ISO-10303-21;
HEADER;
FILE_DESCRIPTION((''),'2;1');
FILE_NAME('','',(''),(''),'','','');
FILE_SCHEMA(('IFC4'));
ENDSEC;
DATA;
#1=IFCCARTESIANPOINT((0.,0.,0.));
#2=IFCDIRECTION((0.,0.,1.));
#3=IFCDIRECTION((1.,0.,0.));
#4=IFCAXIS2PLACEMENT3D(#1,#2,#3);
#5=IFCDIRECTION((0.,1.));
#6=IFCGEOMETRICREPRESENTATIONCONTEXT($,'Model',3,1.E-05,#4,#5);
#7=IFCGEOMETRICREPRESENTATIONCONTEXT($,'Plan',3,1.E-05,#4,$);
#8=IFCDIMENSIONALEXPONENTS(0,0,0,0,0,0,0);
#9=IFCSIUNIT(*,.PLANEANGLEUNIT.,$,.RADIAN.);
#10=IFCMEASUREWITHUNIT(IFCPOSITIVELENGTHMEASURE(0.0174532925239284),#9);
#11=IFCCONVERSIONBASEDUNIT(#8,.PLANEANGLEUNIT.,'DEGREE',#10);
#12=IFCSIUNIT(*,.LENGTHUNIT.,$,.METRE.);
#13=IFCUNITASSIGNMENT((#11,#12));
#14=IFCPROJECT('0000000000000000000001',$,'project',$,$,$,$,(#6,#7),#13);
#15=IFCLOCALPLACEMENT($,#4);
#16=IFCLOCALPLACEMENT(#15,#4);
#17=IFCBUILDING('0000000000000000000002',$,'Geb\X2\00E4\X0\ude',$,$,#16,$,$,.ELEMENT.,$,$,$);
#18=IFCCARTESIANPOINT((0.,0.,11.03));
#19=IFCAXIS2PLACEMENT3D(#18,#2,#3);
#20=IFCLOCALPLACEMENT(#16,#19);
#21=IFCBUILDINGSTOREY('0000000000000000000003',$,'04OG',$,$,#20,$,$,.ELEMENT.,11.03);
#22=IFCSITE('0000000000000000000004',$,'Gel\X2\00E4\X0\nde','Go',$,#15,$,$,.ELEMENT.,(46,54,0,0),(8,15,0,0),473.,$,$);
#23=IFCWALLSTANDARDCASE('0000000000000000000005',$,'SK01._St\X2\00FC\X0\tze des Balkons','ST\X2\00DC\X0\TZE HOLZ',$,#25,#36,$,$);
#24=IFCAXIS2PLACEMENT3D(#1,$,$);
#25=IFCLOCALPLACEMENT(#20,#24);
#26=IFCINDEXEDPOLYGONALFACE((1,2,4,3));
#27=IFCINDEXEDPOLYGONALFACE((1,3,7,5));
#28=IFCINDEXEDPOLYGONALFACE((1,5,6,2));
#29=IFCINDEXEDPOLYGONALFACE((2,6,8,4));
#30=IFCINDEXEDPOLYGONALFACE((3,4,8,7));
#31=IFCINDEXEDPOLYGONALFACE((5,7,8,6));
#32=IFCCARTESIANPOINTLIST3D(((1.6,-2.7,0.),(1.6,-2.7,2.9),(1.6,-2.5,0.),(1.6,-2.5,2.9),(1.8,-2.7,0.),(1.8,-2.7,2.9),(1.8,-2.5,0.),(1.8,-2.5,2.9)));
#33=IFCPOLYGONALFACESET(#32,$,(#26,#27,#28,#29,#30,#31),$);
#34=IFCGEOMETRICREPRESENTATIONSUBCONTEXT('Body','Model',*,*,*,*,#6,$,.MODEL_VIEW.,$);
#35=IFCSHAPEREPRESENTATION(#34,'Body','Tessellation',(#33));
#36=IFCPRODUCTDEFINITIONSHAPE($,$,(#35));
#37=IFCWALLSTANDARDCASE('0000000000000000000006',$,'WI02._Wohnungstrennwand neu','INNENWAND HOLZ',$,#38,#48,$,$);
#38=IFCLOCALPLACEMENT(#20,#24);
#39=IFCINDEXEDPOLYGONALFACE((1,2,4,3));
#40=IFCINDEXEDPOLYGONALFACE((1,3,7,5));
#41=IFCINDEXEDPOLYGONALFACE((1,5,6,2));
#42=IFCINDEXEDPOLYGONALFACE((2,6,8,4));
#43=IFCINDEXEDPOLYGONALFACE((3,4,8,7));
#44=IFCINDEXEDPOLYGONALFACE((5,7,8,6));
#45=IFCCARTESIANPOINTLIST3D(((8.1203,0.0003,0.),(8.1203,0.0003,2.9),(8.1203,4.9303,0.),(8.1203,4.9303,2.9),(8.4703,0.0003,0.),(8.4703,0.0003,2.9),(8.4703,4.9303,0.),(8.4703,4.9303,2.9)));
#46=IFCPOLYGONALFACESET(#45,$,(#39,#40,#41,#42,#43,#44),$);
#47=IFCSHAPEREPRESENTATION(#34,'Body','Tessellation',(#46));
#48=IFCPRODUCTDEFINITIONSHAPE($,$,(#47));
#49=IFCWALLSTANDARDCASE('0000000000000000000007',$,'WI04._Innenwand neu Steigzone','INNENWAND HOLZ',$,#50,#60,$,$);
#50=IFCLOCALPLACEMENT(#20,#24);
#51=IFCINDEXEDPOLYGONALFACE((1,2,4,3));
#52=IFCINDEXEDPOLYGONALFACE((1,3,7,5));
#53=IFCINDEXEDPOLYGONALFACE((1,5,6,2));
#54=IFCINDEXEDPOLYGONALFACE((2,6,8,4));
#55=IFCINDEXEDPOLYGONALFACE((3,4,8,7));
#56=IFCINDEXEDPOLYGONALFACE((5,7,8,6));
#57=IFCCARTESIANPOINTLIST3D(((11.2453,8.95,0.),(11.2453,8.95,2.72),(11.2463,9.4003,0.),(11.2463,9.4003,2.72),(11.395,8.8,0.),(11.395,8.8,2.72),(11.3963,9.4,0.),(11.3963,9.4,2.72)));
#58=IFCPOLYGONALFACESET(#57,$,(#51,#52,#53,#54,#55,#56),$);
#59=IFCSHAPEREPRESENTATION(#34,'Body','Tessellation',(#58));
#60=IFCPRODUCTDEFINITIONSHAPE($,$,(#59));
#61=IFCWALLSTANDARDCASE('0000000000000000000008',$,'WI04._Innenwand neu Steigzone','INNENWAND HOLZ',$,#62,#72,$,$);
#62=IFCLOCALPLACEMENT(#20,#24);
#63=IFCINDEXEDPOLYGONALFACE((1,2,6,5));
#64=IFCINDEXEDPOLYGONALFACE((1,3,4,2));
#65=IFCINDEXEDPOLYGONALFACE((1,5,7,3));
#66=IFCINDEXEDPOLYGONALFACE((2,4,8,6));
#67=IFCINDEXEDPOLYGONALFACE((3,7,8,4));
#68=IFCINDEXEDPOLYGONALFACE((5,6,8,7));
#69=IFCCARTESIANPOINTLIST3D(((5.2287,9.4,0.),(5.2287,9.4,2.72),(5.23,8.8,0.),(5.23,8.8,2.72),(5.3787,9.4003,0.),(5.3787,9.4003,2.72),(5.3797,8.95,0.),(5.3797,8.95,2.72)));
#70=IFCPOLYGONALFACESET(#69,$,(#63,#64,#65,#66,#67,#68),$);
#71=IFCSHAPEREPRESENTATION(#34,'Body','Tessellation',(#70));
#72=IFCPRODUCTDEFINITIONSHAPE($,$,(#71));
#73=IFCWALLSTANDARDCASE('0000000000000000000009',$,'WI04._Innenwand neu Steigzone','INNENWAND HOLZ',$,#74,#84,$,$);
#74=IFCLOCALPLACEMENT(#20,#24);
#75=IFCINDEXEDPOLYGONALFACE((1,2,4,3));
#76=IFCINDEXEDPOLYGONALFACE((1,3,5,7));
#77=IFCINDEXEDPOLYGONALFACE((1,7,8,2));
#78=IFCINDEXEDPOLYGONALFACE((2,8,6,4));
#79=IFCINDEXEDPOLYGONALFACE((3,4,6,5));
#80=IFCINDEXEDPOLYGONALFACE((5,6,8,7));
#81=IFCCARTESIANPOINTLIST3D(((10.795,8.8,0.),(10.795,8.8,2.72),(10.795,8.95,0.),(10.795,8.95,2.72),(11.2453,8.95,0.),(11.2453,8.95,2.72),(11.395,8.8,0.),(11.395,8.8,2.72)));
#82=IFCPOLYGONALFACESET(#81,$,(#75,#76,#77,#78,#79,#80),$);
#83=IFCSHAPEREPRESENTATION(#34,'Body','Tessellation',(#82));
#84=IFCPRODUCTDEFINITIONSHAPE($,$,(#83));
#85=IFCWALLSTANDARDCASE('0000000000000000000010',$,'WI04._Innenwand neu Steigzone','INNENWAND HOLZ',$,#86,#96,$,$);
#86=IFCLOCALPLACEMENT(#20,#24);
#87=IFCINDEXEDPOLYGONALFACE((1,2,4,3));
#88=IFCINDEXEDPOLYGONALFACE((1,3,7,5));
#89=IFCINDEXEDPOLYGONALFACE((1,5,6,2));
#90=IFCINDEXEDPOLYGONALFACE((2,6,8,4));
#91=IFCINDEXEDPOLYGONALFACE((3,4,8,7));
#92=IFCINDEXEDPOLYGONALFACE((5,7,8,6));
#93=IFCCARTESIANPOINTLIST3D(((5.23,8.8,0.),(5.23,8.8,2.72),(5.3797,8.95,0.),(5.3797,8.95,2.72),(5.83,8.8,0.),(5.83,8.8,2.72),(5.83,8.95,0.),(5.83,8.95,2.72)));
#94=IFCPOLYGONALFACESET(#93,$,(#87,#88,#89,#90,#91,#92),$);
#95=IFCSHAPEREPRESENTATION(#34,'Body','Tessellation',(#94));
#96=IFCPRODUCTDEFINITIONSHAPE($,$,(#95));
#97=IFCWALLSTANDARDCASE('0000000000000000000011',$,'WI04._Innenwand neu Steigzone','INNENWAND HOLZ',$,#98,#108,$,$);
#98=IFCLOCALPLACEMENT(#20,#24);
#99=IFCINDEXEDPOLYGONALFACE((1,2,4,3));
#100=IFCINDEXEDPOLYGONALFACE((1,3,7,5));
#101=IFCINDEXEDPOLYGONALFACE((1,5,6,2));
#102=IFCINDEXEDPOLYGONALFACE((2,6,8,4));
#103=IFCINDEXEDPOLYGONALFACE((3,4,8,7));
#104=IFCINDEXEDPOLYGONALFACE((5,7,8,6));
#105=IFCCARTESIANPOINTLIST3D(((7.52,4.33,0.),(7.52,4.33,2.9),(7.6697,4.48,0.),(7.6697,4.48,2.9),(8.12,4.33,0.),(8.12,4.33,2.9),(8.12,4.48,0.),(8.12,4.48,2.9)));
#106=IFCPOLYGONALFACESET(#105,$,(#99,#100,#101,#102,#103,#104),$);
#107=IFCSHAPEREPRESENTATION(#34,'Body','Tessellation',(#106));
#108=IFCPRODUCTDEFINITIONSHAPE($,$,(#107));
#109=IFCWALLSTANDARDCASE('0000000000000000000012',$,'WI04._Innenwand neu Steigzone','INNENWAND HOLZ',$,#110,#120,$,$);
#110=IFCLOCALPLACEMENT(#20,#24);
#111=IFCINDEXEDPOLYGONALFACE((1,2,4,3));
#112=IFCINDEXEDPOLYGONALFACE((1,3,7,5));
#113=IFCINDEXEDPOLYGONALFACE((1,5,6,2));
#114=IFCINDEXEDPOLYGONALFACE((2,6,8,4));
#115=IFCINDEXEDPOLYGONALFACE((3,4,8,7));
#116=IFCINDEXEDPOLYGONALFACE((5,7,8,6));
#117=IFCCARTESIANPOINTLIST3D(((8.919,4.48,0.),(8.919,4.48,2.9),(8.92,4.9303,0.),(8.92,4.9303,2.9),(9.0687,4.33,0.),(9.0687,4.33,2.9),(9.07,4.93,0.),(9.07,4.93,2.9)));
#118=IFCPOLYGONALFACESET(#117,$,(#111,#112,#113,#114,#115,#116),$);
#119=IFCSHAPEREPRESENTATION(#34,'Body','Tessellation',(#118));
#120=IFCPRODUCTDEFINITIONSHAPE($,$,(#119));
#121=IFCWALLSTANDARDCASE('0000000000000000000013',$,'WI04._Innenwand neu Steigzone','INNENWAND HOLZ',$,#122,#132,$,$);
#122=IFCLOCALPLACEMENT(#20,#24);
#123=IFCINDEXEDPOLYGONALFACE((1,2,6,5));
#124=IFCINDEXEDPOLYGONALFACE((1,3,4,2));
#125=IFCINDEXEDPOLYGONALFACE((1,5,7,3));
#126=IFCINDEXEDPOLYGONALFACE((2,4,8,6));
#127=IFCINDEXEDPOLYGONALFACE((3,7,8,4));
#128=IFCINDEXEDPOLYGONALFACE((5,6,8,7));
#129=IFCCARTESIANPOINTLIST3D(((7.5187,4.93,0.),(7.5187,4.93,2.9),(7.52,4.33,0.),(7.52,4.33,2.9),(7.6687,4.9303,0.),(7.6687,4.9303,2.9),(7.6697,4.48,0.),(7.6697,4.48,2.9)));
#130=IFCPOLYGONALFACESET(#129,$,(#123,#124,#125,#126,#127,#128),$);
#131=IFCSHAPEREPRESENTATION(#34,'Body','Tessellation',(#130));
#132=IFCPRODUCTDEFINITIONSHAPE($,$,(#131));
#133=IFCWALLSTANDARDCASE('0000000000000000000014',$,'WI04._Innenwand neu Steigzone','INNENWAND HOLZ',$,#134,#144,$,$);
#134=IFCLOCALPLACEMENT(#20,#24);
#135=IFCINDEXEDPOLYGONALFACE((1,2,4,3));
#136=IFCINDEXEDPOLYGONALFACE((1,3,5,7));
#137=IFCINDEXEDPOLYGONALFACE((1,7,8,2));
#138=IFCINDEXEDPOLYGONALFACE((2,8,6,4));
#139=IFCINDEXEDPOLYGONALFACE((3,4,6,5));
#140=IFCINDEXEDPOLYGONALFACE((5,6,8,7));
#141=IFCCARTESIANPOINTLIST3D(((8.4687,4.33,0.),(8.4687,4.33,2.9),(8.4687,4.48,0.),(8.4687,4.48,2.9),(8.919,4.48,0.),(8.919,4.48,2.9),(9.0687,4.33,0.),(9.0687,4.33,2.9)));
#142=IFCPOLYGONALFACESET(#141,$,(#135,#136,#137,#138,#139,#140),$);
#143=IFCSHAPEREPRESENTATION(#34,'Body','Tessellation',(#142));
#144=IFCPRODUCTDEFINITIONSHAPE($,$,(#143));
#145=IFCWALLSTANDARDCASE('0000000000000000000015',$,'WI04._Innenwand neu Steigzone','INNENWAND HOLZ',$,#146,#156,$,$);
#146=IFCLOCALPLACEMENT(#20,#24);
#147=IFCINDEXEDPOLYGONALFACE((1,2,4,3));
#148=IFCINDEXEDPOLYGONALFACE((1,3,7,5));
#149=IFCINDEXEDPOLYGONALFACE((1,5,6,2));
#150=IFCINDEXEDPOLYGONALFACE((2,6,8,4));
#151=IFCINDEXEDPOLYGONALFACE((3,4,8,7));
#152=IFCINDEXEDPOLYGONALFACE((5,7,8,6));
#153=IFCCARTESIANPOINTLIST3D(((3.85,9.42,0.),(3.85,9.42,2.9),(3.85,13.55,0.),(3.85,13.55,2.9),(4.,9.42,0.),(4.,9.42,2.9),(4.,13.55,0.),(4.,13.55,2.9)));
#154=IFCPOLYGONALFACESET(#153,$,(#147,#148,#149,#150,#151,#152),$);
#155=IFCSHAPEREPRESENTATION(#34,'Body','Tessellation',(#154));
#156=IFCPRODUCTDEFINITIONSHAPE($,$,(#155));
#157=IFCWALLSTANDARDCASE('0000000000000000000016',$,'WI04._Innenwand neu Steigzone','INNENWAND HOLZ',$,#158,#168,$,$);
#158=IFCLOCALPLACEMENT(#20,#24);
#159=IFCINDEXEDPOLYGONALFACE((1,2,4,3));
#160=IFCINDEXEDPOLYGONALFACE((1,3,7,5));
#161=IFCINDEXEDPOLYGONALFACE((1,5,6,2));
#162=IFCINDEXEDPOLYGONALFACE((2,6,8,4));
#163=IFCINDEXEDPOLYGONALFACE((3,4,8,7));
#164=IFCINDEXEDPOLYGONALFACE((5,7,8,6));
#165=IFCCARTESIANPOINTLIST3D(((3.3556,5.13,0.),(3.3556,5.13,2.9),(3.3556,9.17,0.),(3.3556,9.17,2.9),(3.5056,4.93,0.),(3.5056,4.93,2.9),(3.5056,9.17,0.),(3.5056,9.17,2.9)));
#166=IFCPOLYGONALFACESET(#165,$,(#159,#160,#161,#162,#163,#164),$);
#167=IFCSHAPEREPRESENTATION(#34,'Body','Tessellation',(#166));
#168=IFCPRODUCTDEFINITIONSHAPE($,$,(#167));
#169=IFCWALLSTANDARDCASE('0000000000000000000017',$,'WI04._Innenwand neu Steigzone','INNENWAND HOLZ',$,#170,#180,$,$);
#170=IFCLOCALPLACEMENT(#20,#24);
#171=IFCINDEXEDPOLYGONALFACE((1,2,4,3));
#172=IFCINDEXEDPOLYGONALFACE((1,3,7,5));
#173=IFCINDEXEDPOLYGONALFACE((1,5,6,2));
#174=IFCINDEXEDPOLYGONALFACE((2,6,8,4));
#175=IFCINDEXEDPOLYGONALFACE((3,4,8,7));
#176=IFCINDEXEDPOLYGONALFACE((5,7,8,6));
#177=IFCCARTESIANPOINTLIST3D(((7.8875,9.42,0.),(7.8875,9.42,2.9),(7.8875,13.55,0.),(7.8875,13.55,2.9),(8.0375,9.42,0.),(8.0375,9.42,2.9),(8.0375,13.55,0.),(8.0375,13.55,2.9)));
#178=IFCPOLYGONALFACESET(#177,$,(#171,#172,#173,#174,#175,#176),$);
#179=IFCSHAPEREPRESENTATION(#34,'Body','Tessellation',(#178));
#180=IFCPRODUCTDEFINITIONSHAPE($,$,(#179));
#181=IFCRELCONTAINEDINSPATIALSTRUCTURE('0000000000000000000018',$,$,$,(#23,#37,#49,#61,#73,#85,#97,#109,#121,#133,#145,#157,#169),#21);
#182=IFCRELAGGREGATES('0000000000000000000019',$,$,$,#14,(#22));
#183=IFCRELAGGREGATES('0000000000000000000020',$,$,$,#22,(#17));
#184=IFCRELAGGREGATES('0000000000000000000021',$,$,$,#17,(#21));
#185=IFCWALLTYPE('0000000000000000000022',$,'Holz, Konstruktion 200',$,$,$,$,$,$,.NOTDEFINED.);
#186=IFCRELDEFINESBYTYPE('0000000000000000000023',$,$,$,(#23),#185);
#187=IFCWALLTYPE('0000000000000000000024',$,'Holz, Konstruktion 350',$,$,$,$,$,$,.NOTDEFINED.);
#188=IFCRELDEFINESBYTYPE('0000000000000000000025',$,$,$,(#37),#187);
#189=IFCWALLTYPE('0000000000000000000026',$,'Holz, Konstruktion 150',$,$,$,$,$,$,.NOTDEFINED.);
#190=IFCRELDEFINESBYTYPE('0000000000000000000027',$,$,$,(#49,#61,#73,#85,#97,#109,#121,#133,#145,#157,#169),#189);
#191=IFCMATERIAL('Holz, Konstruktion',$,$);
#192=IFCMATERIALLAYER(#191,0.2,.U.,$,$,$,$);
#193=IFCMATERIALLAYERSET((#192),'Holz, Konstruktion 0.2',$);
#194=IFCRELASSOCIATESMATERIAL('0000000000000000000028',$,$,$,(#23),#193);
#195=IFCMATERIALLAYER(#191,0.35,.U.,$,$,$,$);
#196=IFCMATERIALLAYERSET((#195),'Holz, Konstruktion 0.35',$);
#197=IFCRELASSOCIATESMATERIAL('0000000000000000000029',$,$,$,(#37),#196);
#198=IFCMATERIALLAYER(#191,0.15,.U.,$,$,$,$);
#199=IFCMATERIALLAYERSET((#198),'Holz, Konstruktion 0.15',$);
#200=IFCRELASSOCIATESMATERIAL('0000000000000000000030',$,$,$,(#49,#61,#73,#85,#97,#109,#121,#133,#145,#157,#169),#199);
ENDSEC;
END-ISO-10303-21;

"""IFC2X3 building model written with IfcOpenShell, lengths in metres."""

from ifc_helpers import new_model, entity, si_unit, converted_unit, direction, frame, origin_with_axes, place, context, subcontext, project, spatial, polyline, outline, extrude, material, layer, layer_set, layer_usage, type_object, element, save


model = new_model("IFC2X3")

# Units and contexts
model_context = context("Model", 3, precision=1e-05, world=origin_with_axes(), true_north=direction((0.0, 1.0)))
plan_context = context("Plan", 3, precision=1e-05, world=origin_with_axes())
body_context = subcontext(model_context, "Body", "Model", "MODEL_VIEW")
ifc_project = project(units=[converted_unit("PLANEANGLEUNIT", "DEGREE", entity("IfcPositiveLengthMeasure", 0.0174532925239284), si_unit("PLANEANGLEUNIT", "RADIAN"), dimensions=[0, 0, 0, 0, 0, 0, 0]), si_unit("LENGTHUNIT", "METRE")], contexts=[model_context, plan_context])

# Site, building, storey
site_placement = place(None, origin_with_axes())
site = spatial("IfcSite", under=ifc_project, at=site_placement, Name="Gelände", Description="Go", CompositionType="ELEMENT", RefLatitude=(46, 54, 0, 0), RefLongitude=(8, 15, 0, 0), RefElevation=473.0)
building_placement = place(site_placement, origin_with_axes())
building = spatial("IfcBuilding", under=site, at=building_placement, Name="Gebäude", CompositionType="ELEMENT")
storey_placement = place(building_placement, frame((0.0, 0.0, 11.03), z_axis=(0.0, 0.0, 1.0), x_axis=(1.0, 0.0, 0.0)))
storey = spatial("IfcBuildingStorey", under=building, at=storey_placement, Name="04OG", CompositionType="ELEMENT", Elevation=11.03)

# Shared definitions
ifc_material_1 = material(Name="Holz, Konstruktion")

# Walls
ifc_layer_1 = layer(ifc_material_1, 0.2, ventilated="UNKNOWN")
ifc_layer_set_1 = layer_set([ifc_layer_1], Name="Holz, Konstruktion 0.2")
wall_type_1 = type_object("IfcWallType", Name="Holz, Konstruktion 200", PredefinedType="NOTDEFINED")
ifc_layer_usage_1 = layer_usage(ifc_layer_set_1, "AXIS2", "NEGATIVE", 0.0)
wall_1_placement = place(storey_placement, frame((1.6, -2.7, 0.0), z_axis=(0.0, 0.0, 1.0), x_axis=(0.0, 1.0, 0.0)))
element("IfcWallStandardCase", 1, at=wall_1_placement, inside=storey, type_object=wall_type_1, material=ifc_layer_usage_1, Name="SK01._Stütze des Balkons", Description="STÜTZE HOLZ", context=body_context, shape_type="SweptSolid", body=[
    extrude(outline(polyline([(0.0, -0.2), (0.2, -0.2), (0.2, 0.0), (0.0, 0.0), (0.0, -0.2)])), origin_with_axes(), (0.0, 0.0, 1.0), 2.9),
])
ifc_layer_2 = layer(ifc_material_1, 0.35, ventilated="UNKNOWN")
ifc_layer_set_2 = layer_set([ifc_layer_2], Name="Holz, Konstruktion 0.35")
ifc_layer_usage_2 = layer_usage(ifc_layer_set_2, "AXIS2", "POSITIVE", 0.0)
wall_type_2 = type_object("IfcWallType", Name="Holz, Konstruktion 350", PredefinedType="NOTDEFINED")
wall_2_placement = place(storey_placement, frame((8.1203, 4.9303, 0.0), z_axis=(0.0, 0.0, 1.0), x_axis=(0.0, -1.0, 0.0)))
element("IfcWallStandardCase", 2, at=wall_2_placement, inside=storey, type_object=wall_type_2, material=ifc_layer_usage_2, Name="WI02._Wohnungstrennwand neu", Description="INNENWAND HOLZ", context=body_context, shape_type="SweptSolid", body=[
    extrude(outline(polyline([(0.0, 0.0), (4.93, 0.0), (4.93, 0.35), (0.0, 0.35), (0.0, 0.0)])), origin_with_axes(), (0.0, 0.0, 1.0), 2.9),
])
ifc_layer_3 = layer(ifc_material_1, 0.15, ventilated="UNKNOWN")
ifc_layer_set_3 = layer_set([ifc_layer_3], Name="Holz, Konstruktion 0.15")
ifc_layer_usage_3 = layer_usage(ifc_layer_set_3, "AXIS2", "NEGATIVE", 0.0)
wall_type_3 = type_object("IfcWallType", Name="Holz, Konstruktion 150", PredefinedType="NOTDEFINED")
wall_3_placement = place(storey_placement, frame((11.3963, 9.4, 0.0), z_axis=(0.0, 0.0, 1.0), x_axis=(-0.002118, -0.999998, 0.0)))
element("IfcWallStandardCase", 3, at=wall_3_placement, inside=storey, type_object=wall_type_3, material=ifc_layer_usage_3, Name="WI04._Innenwand neu Steigzone", Description="INNENWAND HOLZ", context=body_context, shape_type="SweptSolid", body=[
    extrude(outline(polyline([(0.0, -0.15), (0.4503, -0.15), (0.6, 0.0), (0.0, 0.0), (0.0, -0.15)])), origin_with_axes(), (0.0, 0.0, 1.0), 2.72),
])
ifc_layer_usage_4 = layer_usage(ifc_layer_set_3, "AXIS2", "POSITIVE", 0.0)
wall_4_placement = place(storey_placement, frame((5.2287, 9.4, 0.0), z_axis=(0.0, 0.0, 1.0), x_axis=(0.002118, -0.999998, 0.0)))
element("IfcWallStandardCase", 4, at=wall_4_placement, inside=storey, type_object=wall_type_3, material=ifc_layer_usage_4, Name="WI04._Innenwand neu Steigzone", Description="INNENWAND HOLZ", context=body_context, shape_type="SweptSolid", body=[
    extrude(outline(polyline([(0.0, 0.0), (0.6, 0.0), (0.4503, 0.15), (0.0, 0.15), (0.0, 0.0)])), origin_with_axes(), (0.0, 0.0, 1.0), 2.72),
])
ifc_layer_usage_5 = layer_usage(ifc_layer_set_3, "AXIS2", "NEGATIVE", 0.0)
wall_5_placement = place(storey_placement, frame((11.395, 8.8, 0.0), z_axis=(0.0, 0.0, 1.0), x_axis=(-1.0, 0.0, 0.0)))
element("IfcWallStandardCase", 5, at=wall_5_placement, inside=storey, type_object=wall_type_3, material=ifc_layer_usage_5, Name="WI04._Innenwand neu Steigzone", Description="INNENWAND HOLZ", context=body_context, shape_type="SweptSolid", body=[
    extrude(outline(polyline([(0.1497, -0.15), (0.6, -0.15), (0.6, 0.0), (0.0, 0.0), (0.1497, -0.15)])), origin_with_axes(), (0.0, 0.0, 1.0), 2.72),
])
ifc_layer_usage_6 = layer_usage(ifc_layer_set_3, "AXIS2", "POSITIVE", 0.0)
wall_6_placement = place(storey_placement, frame((5.23, 8.8, 0.0), z_axis=(0.0, 0.0, 1.0), x_axis=(1.0, 0.0, 0.0)))
element("IfcWallStandardCase", 6, at=wall_6_placement, inside=storey, type_object=wall_type_3, material=ifc_layer_usage_6, Name="WI04._Innenwand neu Steigzone", Description="INNENWAND HOLZ", context=body_context, shape_type="SweptSolid", body=[
    extrude(outline(polyline([(0.0, 0.0), (0.6, 0.0), (0.6, 0.15), (0.1497, 0.15), (0.0, 0.0)])), origin_with_axes(), (0.0, 0.0, 1.0), 2.72),
])
ifc_layer_usage_7 = layer_usage(ifc_layer_set_3, "AXIS2", "POSITIVE", 0.0)
wall_7_placement = place(storey_placement, frame((7.52, 4.33, 0.0), z_axis=(0.0, 0.0, 1.0), x_axis=(1.0, 0.0, 0.0)))
element("IfcWallStandardCase", 7, at=wall_7_placement, inside=storey, type_object=wall_type_3, material=ifc_layer_usage_7, Name="WI04._Innenwand neu Steigzone", Description="INNENWAND HOLZ", context=body_context, shape_type="SweptSolid", body=[
    extrude(outline(polyline([(0.0, 0.0), (0.6, 0.0), (0.6, 0.15), (0.1497, 0.15), (0.0, 0.0)])), origin_with_axes(), (0.0, 0.0, 1.0), 2.9),
])
ifc_layer_usage_8 = layer_usage(ifc_layer_set_3, "AXIS2", "POSITIVE", 0.0)
wall_8_placement = place(storey_placement, frame((9.0687, 4.33, 0.0), z_axis=(0.0, 0.0, 1.0), x_axis=(0.002118, 0.999998, 0.0)))
element("IfcWallStandardCase", 8, at=wall_8_placement, inside=storey, type_object=wall_type_3, material=ifc_layer_usage_8, Name="WI04._Innenwand neu Steigzone", Description="INNENWAND HOLZ", context=body_context, shape_type="SweptSolid", body=[
    extrude(outline(polyline([(0.0, 0.0), (0.6, 0.0), (0.6, 0.15), (0.1497, 0.15), (0.0, 0.0)])), origin_with_axes(), (0.0, 0.0, 1.0), 2.9),
])
ifc_layer_usage_9 = layer_usage(ifc_layer_set_3, "AXIS2", "POSITIVE", 0.0)
wall_9_placement = place(storey_placement, frame((7.5187, 4.93, 0.0), z_axis=(0.0, 0.0, 1.0), x_axis=(0.002118, -0.999998, 0.0)))
element("IfcWallStandardCase", 9, at=wall_9_placement, inside=storey, type_object=wall_type_3, material=ifc_layer_usage_9, Name="WI04._Innenwand neu Steigzone", Description="INNENWAND HOLZ", context=body_context, shape_type="SweptSolid", body=[
    extrude(outline(polyline([(0.0, 0.0), (0.6, 0.0), (0.4503, 0.15), (0.0, 0.15), (0.0, 0.0)])), origin_with_axes(), (0.0, 0.0, 1.0), 2.9),
])
ifc_layer_usage_10 = layer_usage(ifc_layer_set_3, "AXIS2", "POSITIVE", 0.0)
wall_10_placement = place(storey_placement, frame((8.4687, 4.33, 0.0), z_axis=(0.0, 0.0, 1.0), x_axis=(1.0, 0.0, 0.0)))
element("IfcWallStandardCase", 10, at=wall_10_placement, inside=storey, type_object=wall_type_3, material=ifc_layer_usage_10, Name="WI04._Innenwand neu Steigzone", Description="INNENWAND HOLZ", context=body_context, shape_type="SweptSolid", body=[
    extrude(outline(polyline([(0.0, 0.0), (0.6, 0.0), (0.4503, 0.15), (0.0, 0.15), (0.0, 0.0)])), origin_with_axes(), (0.0, 0.0, 1.0), 2.9),
])
ifc_layer_usage_11 = layer_usage(ifc_layer_set_3, "AXIS2", "NEGATIVE", 0.0)
wall_11_placement = place(storey_placement, frame((4.0, 13.55, 0.0), z_axis=(0.0, 0.0, 1.0), x_axis=(0.0, -1.0, 0.0)))
element("IfcWallStandardCase", 11, at=wall_11_placement, inside=storey, type_object=wall_type_3, material=ifc_layer_usage_11, Name="WI04._Innenwand neu Steigzone", Description="INNENWAND HOLZ", context=body_context, shape_type="SweptSolid", body=[
    extrude(outline(polyline([(0.0, -0.15), (4.13, -0.15), (4.13, 0.0), (0.0, 0.0), (0.0, -0.15)])), origin_with_axes(), (0.0, 0.0, 1.0), 2.9),
])
ifc_layer_usage_12 = layer_usage(ifc_layer_set_3, "AXIS2", "NEGATIVE", 0.0)
wall_12_placement = place(storey_placement, frame((3.5056, 9.17, 0.0), z_axis=(0.0, 0.0, 1.0), x_axis=(0.0, -1.0, 0.0)))
element("IfcWallStandardCase", 12, at=wall_12_placement, inside=storey, type_object=wall_type_3, material=ifc_layer_usage_12, Name="WI04._Innenwand neu Steigzone", Description="INNENWAND HOLZ", context=body_context, shape_type="SweptSolid", body=[
    extrude(outline(polyline([(0.0, -0.15), (4.04, -0.15), (4.24, 0.0), (0.0, 0.0), (0.0, -0.15)])), origin_with_axes(), (0.0, 0.0, 1.0), 2.9),
])
ifc_layer_usage_13 = layer_usage(ifc_layer_set_3, "AXIS2", "POSITIVE", 0.0)
wall_13_placement = place(storey_placement, frame((7.8875, 13.55, 0.0), z_axis=(0.0, 0.0, 1.0), x_axis=(0.0, -1.0, 0.0)))
element("IfcWallStandardCase", 13, at=wall_13_placement, inside=storey, type_object=wall_type_3, material=ifc_layer_usage_13, Name="WI04._Innenwand neu Steigzone", Description="INNENWAND HOLZ", context=body_context, shape_type="SweptSolid", body=[
    extrude(outline(polyline([(0.0, 0.0), (4.13, 0.0), (4.13, 0.15), (0.0, 0.15), (0.0, 0.0)])), origin_with_axes(), (0.0, 0.0, 1.0), 2.9),
])

save(model, "model.ifc")
